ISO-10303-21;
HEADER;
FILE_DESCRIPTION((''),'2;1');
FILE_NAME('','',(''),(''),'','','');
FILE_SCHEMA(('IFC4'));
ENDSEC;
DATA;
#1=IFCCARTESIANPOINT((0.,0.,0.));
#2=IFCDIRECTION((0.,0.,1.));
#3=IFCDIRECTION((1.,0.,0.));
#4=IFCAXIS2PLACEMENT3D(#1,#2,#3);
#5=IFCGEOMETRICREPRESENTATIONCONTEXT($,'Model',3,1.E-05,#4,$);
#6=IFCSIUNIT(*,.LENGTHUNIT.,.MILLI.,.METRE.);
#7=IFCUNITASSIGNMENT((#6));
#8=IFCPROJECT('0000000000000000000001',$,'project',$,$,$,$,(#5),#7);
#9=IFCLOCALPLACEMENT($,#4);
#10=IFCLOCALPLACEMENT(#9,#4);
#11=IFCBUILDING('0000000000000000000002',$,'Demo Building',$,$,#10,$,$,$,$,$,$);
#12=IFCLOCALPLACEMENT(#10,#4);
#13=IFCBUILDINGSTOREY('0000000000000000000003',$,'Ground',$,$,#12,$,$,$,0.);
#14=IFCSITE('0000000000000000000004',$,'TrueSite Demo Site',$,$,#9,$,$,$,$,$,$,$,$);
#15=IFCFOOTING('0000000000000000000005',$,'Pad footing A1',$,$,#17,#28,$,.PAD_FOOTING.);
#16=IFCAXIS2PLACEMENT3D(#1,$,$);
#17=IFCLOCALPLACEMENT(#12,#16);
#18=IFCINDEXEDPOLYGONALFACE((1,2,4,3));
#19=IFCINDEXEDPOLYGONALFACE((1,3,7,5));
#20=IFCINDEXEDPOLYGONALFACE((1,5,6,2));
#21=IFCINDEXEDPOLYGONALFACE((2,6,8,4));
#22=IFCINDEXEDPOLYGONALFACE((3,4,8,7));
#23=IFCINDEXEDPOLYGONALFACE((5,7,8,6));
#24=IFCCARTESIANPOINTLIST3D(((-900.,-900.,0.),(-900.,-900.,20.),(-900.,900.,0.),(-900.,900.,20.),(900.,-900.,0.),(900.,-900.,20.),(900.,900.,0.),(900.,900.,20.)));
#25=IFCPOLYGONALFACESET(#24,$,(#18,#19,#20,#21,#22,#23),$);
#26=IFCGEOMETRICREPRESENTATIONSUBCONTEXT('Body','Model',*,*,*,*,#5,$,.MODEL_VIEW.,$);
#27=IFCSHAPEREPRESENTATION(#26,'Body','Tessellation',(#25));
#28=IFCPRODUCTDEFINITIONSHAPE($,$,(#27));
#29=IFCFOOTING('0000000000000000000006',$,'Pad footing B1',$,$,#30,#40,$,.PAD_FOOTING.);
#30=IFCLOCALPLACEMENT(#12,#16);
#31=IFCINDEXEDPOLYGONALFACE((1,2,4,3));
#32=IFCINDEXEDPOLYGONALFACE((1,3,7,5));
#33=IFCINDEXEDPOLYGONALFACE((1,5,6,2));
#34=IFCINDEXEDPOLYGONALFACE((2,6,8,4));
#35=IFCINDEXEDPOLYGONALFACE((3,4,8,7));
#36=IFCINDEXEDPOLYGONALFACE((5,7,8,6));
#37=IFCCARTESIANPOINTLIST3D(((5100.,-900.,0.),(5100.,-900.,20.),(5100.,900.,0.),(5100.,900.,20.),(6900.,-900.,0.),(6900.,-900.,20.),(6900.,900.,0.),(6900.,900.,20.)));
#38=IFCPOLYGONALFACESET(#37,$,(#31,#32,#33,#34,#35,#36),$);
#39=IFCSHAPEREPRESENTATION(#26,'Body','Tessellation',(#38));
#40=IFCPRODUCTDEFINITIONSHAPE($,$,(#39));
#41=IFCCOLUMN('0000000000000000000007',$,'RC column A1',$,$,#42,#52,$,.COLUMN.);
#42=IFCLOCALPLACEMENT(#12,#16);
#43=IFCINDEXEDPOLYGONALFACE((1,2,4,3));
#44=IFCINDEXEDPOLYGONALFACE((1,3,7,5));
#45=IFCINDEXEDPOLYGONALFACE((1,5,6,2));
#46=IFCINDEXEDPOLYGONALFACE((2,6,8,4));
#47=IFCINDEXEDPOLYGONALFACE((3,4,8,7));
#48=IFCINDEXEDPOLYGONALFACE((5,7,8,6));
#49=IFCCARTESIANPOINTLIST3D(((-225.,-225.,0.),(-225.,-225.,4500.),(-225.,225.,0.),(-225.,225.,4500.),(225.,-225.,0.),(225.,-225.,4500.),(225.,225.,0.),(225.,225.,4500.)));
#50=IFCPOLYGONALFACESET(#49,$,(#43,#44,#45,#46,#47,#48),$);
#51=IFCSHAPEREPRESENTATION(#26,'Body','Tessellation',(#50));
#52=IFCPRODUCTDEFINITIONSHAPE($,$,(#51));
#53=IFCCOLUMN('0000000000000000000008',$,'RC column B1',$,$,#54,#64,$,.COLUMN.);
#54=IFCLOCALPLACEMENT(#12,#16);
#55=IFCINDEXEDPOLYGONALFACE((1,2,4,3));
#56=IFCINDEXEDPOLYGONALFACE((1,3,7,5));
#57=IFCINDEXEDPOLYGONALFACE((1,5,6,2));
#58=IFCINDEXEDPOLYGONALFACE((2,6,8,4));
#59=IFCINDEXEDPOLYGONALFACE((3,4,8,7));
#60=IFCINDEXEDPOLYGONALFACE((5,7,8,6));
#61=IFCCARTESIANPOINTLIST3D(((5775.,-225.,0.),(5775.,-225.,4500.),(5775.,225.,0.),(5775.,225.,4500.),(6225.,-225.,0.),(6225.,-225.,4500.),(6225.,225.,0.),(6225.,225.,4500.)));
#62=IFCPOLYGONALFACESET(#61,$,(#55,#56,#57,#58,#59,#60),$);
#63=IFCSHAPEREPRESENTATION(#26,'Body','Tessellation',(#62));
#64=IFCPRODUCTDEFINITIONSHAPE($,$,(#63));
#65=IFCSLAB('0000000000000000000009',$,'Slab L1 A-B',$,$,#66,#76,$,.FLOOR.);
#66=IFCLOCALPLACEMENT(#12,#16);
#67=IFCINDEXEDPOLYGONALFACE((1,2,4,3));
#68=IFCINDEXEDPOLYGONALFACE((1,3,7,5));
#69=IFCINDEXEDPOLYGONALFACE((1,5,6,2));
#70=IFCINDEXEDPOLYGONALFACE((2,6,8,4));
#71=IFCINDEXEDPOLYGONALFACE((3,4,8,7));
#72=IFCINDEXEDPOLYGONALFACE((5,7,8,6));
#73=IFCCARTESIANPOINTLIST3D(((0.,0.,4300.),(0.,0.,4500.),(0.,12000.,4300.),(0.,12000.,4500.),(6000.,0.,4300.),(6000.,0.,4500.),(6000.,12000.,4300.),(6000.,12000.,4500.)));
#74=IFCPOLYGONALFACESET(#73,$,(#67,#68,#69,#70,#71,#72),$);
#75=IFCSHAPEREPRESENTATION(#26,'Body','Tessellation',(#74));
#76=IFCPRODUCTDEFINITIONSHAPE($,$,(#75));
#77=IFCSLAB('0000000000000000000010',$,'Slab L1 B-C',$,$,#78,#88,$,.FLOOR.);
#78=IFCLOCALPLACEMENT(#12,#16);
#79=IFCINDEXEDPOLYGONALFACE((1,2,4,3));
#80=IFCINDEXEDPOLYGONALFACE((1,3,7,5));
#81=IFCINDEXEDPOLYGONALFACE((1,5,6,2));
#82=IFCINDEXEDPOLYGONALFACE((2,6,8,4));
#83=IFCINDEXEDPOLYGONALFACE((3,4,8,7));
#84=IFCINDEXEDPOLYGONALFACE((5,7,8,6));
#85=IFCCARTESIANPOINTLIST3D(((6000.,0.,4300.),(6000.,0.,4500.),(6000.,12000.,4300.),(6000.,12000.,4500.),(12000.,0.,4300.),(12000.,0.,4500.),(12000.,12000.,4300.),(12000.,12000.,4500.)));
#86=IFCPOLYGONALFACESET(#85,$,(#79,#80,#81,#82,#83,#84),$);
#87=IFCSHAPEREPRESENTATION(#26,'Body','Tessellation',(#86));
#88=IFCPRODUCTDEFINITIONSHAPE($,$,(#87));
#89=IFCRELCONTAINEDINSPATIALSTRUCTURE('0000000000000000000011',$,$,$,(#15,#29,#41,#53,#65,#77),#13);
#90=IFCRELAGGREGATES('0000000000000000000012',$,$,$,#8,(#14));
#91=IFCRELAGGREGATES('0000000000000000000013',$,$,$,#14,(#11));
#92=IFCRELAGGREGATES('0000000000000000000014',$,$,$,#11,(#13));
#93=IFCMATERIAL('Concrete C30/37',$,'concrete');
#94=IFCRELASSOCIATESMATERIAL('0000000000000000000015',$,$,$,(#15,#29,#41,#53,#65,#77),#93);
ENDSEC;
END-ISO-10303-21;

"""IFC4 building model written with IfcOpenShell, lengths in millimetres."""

from ifc_helpers import new_model, si_unit, frame, origin_with_axes, place, context, subcontext, project, spatial, rectangle, extrude, material, element, save


model = new_model("IFC4")

# Units and contexts
model_context = context("Model", 3, precision=1e-05, world=origin_with_axes())
body_context = subcontext(model_context, "Body", "Model", "MODEL_VIEW")
ifc_project = project(units=[si_unit("LENGTHUNIT", "METRE", prefix="MILLI")], contexts=[model_context])

# Site, building, storey
site_placement = place(None, origin_with_axes())
site = spatial("IfcSite", under=ifc_project, at=site_placement, Name="TrueSite Demo Site")
building_placement = place(site_placement, origin_with_axes())
building = spatial("IfcBuilding", under=site, at=building_placement, Name="Demo Building")
storey_placement = place(building_placement, origin_with_axes())
storey = spatial("IfcBuildingStorey", under=building, at=storey_placement, Name="Ground", Elevation=0.0)

# Footings
ifc_material_1 = material(Name="Concrete C30/37", Category="concrete")
for number, where, z_axis, x_axis, name in (
    (1, (0.0, 0.0, 0.0), (0.0, 0.0, 1.0), (1.0, 0.0, 0.0), "Pad footing A1"),
    (2, (6000.0, 0.0, 0.0), (0.0, 0.0, 1.0), (1.0, 0.0, 0.0), "Pad footing B1"),
):
    element("IfcFooting", number, at=place(storey_placement, frame(where, z_axis=z_axis, x_axis=x_axis)), inside=storey, material=ifc_material_1, Name=name, PredefinedType="PAD_FOOTING", context=body_context, shape_type="SweptSolid", body=[
        extrude(rectangle(XDim=1800.0, YDim=1800.0), origin_with_axes(), (0.0, 0.0, 1.0), 20.0),
    ])

# Columns
for number, where, z_axis, x_axis, name in (
    (3, (0.0, 0.0, 0.0), (0.0, 0.0, 1.0), (1.0, 0.0, 0.0), "RC column A1"),
    (4, (6000.0, 0.0, 0.0), (0.0, 0.0, 1.0), (1.0, 0.0, 0.0), "RC column B1"),
):
    element("IfcColumn", number, at=place(storey_placement, frame(where, z_axis=z_axis, x_axis=x_axis)), inside=storey, material=ifc_material_1, Name=name, PredefinedType="COLUMN", context=body_context, shape_type="SweptSolid", body=[
        extrude(rectangle(XDim=450.0, YDim=450.0), origin_with_axes(), (0.0, 0.0, 1.0), 4500.0),
    ])

# Slabs
slab_1_placement = place(storey_placement, origin_with_axes())
element("IfcSlab", 5, at=slab_1_placement, inside=storey, material=ifc_material_1, Name="Slab L1 A-B", PredefinedType="FLOOR", context=body_context, shape_type="SweptSolid", body=[
    extrude(rectangle(XDim=6000.0, YDim=12000.0), frame((3000.0, 6000.0, 4300.0), z_axis=(0.0, 0.0, 1.0), x_axis=(1.0, 0.0, 0.0)), (0.0, 0.0, 1.0), 200.0),
])
slab_2_placement = place(storey_placement, origin_with_axes())
element("IfcSlab", 6, at=slab_2_placement, inside=storey, material=ifc_material_1, Name="Slab L1 B-C", PredefinedType="FLOOR", context=body_context, shape_type="SweptSolid", body=[
    extrude(rectangle(XDim=6000.0, YDim=12000.0), frame((9000.0, 6000.0, 4300.0), z_axis=(0.0, 0.0, 1.0), x_axis=(1.0, 0.0, 0.0)), (0.0, 0.0, 1.0), 200.0),
])

save(model, "model.ifc")
